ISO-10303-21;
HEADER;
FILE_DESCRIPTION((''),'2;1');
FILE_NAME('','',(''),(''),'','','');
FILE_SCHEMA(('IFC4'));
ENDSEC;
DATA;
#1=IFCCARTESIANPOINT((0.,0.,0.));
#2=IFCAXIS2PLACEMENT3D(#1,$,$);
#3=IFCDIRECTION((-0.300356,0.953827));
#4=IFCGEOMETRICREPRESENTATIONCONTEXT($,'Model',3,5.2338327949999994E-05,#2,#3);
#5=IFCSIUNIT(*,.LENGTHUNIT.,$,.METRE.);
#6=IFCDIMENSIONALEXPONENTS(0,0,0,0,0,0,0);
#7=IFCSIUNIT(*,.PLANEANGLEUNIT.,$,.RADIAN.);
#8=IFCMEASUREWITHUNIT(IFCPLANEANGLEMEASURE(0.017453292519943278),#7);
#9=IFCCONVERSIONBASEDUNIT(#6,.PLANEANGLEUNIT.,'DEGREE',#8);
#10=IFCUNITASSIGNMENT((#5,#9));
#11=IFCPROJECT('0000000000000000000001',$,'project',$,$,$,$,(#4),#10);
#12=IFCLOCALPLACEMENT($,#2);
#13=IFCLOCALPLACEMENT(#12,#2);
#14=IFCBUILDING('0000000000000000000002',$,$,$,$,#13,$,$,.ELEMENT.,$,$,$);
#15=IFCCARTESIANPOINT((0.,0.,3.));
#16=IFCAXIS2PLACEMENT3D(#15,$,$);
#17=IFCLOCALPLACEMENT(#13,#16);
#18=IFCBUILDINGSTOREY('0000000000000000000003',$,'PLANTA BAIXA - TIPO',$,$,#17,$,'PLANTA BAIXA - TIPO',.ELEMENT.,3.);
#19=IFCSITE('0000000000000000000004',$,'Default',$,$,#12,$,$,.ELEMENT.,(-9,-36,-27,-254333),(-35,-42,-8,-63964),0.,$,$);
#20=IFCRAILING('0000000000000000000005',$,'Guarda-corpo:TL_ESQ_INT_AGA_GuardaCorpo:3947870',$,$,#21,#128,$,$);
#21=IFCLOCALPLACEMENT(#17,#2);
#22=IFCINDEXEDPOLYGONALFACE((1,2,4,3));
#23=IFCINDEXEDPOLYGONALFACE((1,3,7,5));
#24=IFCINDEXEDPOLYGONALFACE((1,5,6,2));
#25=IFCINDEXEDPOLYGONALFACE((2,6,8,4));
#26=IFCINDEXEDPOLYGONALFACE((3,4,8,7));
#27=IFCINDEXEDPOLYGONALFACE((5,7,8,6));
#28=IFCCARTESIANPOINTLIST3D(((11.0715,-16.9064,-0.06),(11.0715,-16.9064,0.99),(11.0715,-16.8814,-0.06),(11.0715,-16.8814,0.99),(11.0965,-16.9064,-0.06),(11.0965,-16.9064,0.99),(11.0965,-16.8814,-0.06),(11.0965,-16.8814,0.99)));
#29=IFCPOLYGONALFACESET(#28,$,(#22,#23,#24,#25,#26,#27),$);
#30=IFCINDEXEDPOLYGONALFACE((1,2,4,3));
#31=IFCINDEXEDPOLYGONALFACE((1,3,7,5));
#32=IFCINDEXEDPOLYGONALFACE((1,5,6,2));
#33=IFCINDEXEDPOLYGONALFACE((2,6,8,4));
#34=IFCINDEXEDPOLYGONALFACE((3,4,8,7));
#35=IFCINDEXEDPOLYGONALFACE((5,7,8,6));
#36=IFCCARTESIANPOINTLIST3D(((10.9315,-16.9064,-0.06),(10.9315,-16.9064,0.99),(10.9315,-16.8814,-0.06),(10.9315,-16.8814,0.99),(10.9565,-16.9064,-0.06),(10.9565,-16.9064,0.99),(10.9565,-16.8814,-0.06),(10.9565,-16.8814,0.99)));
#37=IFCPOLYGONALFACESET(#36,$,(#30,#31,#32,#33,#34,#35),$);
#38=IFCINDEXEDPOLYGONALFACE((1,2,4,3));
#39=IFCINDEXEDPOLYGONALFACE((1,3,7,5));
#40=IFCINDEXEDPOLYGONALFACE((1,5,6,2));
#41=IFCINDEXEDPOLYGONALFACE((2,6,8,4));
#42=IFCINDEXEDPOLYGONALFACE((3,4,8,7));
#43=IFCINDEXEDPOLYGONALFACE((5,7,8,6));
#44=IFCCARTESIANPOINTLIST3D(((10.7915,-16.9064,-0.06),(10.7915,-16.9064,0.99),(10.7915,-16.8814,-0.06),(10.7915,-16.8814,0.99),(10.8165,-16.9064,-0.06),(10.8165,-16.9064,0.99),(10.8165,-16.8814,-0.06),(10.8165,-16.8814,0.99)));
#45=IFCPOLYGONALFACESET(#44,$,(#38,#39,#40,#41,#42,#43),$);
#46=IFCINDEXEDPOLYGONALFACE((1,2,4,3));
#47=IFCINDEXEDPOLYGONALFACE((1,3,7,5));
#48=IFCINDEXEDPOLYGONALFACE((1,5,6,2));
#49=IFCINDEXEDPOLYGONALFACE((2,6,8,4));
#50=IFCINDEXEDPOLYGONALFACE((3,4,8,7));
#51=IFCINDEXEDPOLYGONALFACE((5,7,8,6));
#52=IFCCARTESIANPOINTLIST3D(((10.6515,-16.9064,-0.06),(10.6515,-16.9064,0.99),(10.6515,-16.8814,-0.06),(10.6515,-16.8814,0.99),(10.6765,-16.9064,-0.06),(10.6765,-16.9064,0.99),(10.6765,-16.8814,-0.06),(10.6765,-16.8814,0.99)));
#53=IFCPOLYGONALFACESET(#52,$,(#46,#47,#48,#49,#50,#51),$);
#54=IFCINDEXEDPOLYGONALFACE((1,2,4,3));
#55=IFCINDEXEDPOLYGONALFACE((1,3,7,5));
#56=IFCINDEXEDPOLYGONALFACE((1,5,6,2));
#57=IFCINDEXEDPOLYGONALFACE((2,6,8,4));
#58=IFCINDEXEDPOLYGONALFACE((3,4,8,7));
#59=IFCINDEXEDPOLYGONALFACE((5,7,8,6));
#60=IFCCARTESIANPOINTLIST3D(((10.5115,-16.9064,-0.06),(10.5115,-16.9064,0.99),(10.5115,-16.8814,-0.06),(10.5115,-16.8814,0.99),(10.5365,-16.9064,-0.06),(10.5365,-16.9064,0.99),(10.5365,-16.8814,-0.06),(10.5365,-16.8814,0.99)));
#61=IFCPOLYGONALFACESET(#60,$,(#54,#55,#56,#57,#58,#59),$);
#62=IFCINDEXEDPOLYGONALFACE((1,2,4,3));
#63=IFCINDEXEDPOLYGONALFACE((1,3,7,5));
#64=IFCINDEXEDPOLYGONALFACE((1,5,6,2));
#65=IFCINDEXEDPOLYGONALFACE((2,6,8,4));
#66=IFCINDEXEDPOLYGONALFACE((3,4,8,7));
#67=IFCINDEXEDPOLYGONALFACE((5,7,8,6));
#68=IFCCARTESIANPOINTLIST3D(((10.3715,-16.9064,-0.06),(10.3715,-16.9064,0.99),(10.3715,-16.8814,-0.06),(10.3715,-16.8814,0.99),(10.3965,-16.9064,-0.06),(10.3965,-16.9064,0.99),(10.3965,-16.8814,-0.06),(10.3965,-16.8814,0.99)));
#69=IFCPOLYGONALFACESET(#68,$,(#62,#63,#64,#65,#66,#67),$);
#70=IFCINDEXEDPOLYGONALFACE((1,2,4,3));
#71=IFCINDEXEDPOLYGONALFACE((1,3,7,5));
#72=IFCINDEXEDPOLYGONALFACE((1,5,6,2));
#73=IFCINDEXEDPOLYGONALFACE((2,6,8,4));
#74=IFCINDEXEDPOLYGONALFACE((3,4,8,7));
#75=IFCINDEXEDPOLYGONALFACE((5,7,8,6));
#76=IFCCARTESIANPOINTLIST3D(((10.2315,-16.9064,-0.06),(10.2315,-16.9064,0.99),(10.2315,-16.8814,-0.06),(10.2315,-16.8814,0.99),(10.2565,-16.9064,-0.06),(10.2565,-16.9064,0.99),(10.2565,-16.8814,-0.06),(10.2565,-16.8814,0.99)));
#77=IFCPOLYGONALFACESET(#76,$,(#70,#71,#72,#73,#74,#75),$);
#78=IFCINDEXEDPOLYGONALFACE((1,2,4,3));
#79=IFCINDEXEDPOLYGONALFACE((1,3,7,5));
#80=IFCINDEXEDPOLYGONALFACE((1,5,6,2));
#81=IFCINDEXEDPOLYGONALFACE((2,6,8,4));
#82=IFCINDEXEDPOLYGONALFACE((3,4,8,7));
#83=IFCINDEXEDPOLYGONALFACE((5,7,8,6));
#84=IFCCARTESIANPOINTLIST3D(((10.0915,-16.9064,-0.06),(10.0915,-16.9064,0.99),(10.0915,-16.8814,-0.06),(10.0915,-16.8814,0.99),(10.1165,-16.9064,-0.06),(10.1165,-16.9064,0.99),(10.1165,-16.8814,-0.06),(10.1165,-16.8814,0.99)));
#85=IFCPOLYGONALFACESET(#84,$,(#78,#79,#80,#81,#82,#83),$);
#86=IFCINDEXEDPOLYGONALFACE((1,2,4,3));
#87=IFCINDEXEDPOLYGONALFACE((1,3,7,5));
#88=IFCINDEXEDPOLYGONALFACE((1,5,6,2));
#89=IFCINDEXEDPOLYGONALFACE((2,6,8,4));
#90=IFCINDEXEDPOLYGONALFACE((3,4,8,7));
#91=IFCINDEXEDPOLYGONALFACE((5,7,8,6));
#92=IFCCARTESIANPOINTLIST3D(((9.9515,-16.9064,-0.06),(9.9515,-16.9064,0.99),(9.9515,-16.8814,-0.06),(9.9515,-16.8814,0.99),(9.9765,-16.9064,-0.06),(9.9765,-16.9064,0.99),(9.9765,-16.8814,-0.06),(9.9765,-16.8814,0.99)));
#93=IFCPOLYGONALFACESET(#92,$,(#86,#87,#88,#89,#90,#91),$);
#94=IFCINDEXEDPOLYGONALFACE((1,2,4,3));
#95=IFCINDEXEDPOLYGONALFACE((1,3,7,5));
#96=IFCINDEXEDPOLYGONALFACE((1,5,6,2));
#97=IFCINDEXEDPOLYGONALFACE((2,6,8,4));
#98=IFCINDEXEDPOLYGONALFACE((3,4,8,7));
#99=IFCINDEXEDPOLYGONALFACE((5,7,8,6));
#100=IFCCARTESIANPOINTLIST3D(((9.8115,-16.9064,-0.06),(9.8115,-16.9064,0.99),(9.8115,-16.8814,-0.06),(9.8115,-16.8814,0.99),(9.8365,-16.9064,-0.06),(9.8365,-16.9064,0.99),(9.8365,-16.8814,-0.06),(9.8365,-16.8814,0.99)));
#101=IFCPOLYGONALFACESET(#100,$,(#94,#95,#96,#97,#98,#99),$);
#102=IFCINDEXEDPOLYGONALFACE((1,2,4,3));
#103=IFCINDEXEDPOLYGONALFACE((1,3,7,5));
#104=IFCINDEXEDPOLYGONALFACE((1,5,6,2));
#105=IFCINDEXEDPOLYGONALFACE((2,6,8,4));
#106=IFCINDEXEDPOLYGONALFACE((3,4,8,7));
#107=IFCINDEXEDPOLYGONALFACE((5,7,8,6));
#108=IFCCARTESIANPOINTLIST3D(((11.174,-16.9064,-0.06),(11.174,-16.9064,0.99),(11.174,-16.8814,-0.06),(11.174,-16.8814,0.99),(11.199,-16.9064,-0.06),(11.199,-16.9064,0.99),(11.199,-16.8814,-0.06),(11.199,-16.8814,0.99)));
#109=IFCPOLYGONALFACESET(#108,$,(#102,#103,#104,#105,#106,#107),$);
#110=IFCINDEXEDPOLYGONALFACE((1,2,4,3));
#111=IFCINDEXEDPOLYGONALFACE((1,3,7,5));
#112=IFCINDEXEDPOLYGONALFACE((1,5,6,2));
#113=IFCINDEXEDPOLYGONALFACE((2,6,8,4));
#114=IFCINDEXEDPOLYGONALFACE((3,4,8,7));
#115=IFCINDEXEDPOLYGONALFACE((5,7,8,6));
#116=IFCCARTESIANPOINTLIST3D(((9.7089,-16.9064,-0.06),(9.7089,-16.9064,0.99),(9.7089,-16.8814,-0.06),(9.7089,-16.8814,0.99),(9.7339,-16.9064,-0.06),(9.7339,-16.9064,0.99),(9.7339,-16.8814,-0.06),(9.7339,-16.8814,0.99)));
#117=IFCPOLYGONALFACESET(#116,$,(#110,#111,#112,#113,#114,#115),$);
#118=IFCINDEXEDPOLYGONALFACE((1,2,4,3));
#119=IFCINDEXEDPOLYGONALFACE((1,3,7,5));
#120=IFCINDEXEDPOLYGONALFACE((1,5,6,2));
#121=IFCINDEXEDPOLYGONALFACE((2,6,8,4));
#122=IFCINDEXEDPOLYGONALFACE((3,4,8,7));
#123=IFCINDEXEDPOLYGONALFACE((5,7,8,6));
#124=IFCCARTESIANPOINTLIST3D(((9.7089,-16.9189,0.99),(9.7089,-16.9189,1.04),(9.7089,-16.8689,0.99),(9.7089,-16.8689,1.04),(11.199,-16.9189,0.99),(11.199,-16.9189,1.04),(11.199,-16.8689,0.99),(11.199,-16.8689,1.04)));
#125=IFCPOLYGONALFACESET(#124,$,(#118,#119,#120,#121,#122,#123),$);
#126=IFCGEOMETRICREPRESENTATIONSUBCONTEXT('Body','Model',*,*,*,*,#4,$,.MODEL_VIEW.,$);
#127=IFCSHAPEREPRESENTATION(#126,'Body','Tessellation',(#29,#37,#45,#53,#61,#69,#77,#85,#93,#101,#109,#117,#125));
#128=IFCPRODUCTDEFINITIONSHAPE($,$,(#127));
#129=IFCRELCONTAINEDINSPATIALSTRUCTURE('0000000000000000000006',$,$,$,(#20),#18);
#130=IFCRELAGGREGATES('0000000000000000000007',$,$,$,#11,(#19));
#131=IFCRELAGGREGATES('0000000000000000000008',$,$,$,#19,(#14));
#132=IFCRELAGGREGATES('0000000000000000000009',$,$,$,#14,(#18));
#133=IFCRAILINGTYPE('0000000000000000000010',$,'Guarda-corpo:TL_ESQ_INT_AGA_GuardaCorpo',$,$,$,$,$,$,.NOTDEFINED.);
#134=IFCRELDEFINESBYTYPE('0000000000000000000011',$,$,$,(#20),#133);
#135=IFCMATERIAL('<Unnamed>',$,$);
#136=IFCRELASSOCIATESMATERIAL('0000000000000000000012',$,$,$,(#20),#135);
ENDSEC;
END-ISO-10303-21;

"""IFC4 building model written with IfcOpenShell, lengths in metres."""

from ifc_helpers import new_model, entity, si_unit, converted_unit, direction, frame, frame_2d, origin, origin_2d_with_axis, place, context, subcontext, project, spatial, rectangle, extrude, material, type_object, element, save


model = new_model("IFC4")

# Units and contexts
model_context = context("Model", 3, precision=5.2338327949999994e-05, world=origin(), true_north=direction((-0.300356, 0.953827)))
body_context = subcontext(model_context, "Body", "Model", "MODEL_VIEW")
ifc_project = project(units=[si_unit("LENGTHUNIT", "METRE"), converted_unit("PLANEANGLEUNIT", "DEGREE", entity("IfcPlaneAngleMeasure", 0.017453292519943278), si_unit("PLANEANGLEUNIT", "RADIAN"), dimensions=[0, 0, 0, 0, 0, 0, 0])], contexts=[model_context])

# Site, building, storey
site_placement = place(None, origin())
site = spatial("IfcSite", under=ifc_project, at=site_placement, Name="Default", CompositionType="ELEMENT", RefLatitude=(-9, -36, -27, -254333), RefLongitude=(-35, -42, -8, -63964), RefElevation=0.0)
building_placement = place(site_placement, origin())
building = spatial("IfcBuilding", under=site, at=building_placement, CompositionType="ELEMENT")
storey_placement = place(building_placement, frame((0.0, 0.0, 3.0)))
storey = spatial("IfcBuildingStorey", under=building, at=storey_placement, Name="PLANTA BAIXA - TIPO", LongName="PLANTA BAIXA - TIPO", CompositionType="ELEMENT", Elevation=3.0)

# Railing
ifc_material_1 = material(Name="<Unnamed>")
railing_type = type_object("IfcRailingType", Name="Guarda-corpo:TL_ESQ_INT_AGA_GuardaCorpo", PredefinedType="NOTDEFINED")
railing_placement = place(storey_placement, frame((9.7089, -16.9189, -0.06)))
element("IfcRailing", 1, at=railing_placement, inside=storey, type_object=railing_type, material=ifc_material_1, Name="Guarda-corpo:TL_ESQ_INT_AGA_GuardaCorpo:3947870", context=body_context, shape_type="SweptSolid", body=[
    extrude(rectangle(XDim=0.025, YDim=0.025, at=origin_2d_with_axis()), frame((1.375, 0.025, 0.0)), (0.0, 0.0, 1.0), 1.05),
    extrude(rectangle(XDim=0.025, YDim=0.025, at=origin_2d_with_axis()), frame((1.235, 0.025, 0.0)), (0.0, 0.0, 1.0), 1.05),
    extrude(rectangle(XDim=0.025, YDim=0.025, at=origin_2d_with_axis()), frame((1.095, 0.025, 0.0)), (0.0, 0.0, 1.0), 1.05),
    extrude(rectangle(XDim=0.025, YDim=0.025, at=origin_2d_with_axis()), frame((0.955, 0.025, 0.0)), (0.0, 0.0, 1.0), 1.05),
    extrude(rectangle(XDim=0.025, YDim=0.025, at=origin_2d_with_axis()), frame((0.815, 0.025, 0.0)), (0.0, 0.0, 1.0), 1.05),
    extrude(rectangle(XDim=0.025, YDim=0.025, at=origin_2d_with_axis()), frame((0.675, 0.025, 0.0)), (0.0, 0.0, 1.0), 1.05),
    extrude(rectangle(XDim=0.025, YDim=0.025, at=origin_2d_with_axis()), frame((0.535, 0.025, 0.0)), (0.0, 0.0, 1.0), 1.05),
    extrude(rectangle(XDim=0.025, YDim=0.025, at=origin_2d_with_axis()), frame((0.395, 0.025, 0.0)), (0.0, 0.0, 1.0), 1.05),
    extrude(rectangle(XDim=0.025, YDim=0.025, at=origin_2d_with_axis()), frame((0.255, 0.025, 0.0)), (0.0, 0.0, 1.0), 1.05),
    extrude(rectangle(XDim=0.025, YDim=0.025, at=origin_2d_with_axis()), frame((0.115, 0.025, 0.0)), (0.0, 0.0, 1.0), 1.05),
    extrude(rectangle(XDim=0.025, YDim=0.025, at=origin_2d_with_axis()), frame((1.4775, 0.025, 0.0)), (0.0, 0.0, 1.0), 1.05),
    extrude(rectangle(XDim=0.025, YDim=0.025, at=origin_2d_with_axis()), frame((0.0125, 0.025, 0.0)), (0.0, 0.0, 1.0), 1.05),
    extrude(rectangle(XDim=1.49, YDim=0.05, at=frame_2d((0.0, 0.0), x_axis=(1.0, 0.0))), frame((0.745, 0.025, 1.05)), (0.0, 0.0, 1.0), 0.05),
])

save(model, "model.ifc")
